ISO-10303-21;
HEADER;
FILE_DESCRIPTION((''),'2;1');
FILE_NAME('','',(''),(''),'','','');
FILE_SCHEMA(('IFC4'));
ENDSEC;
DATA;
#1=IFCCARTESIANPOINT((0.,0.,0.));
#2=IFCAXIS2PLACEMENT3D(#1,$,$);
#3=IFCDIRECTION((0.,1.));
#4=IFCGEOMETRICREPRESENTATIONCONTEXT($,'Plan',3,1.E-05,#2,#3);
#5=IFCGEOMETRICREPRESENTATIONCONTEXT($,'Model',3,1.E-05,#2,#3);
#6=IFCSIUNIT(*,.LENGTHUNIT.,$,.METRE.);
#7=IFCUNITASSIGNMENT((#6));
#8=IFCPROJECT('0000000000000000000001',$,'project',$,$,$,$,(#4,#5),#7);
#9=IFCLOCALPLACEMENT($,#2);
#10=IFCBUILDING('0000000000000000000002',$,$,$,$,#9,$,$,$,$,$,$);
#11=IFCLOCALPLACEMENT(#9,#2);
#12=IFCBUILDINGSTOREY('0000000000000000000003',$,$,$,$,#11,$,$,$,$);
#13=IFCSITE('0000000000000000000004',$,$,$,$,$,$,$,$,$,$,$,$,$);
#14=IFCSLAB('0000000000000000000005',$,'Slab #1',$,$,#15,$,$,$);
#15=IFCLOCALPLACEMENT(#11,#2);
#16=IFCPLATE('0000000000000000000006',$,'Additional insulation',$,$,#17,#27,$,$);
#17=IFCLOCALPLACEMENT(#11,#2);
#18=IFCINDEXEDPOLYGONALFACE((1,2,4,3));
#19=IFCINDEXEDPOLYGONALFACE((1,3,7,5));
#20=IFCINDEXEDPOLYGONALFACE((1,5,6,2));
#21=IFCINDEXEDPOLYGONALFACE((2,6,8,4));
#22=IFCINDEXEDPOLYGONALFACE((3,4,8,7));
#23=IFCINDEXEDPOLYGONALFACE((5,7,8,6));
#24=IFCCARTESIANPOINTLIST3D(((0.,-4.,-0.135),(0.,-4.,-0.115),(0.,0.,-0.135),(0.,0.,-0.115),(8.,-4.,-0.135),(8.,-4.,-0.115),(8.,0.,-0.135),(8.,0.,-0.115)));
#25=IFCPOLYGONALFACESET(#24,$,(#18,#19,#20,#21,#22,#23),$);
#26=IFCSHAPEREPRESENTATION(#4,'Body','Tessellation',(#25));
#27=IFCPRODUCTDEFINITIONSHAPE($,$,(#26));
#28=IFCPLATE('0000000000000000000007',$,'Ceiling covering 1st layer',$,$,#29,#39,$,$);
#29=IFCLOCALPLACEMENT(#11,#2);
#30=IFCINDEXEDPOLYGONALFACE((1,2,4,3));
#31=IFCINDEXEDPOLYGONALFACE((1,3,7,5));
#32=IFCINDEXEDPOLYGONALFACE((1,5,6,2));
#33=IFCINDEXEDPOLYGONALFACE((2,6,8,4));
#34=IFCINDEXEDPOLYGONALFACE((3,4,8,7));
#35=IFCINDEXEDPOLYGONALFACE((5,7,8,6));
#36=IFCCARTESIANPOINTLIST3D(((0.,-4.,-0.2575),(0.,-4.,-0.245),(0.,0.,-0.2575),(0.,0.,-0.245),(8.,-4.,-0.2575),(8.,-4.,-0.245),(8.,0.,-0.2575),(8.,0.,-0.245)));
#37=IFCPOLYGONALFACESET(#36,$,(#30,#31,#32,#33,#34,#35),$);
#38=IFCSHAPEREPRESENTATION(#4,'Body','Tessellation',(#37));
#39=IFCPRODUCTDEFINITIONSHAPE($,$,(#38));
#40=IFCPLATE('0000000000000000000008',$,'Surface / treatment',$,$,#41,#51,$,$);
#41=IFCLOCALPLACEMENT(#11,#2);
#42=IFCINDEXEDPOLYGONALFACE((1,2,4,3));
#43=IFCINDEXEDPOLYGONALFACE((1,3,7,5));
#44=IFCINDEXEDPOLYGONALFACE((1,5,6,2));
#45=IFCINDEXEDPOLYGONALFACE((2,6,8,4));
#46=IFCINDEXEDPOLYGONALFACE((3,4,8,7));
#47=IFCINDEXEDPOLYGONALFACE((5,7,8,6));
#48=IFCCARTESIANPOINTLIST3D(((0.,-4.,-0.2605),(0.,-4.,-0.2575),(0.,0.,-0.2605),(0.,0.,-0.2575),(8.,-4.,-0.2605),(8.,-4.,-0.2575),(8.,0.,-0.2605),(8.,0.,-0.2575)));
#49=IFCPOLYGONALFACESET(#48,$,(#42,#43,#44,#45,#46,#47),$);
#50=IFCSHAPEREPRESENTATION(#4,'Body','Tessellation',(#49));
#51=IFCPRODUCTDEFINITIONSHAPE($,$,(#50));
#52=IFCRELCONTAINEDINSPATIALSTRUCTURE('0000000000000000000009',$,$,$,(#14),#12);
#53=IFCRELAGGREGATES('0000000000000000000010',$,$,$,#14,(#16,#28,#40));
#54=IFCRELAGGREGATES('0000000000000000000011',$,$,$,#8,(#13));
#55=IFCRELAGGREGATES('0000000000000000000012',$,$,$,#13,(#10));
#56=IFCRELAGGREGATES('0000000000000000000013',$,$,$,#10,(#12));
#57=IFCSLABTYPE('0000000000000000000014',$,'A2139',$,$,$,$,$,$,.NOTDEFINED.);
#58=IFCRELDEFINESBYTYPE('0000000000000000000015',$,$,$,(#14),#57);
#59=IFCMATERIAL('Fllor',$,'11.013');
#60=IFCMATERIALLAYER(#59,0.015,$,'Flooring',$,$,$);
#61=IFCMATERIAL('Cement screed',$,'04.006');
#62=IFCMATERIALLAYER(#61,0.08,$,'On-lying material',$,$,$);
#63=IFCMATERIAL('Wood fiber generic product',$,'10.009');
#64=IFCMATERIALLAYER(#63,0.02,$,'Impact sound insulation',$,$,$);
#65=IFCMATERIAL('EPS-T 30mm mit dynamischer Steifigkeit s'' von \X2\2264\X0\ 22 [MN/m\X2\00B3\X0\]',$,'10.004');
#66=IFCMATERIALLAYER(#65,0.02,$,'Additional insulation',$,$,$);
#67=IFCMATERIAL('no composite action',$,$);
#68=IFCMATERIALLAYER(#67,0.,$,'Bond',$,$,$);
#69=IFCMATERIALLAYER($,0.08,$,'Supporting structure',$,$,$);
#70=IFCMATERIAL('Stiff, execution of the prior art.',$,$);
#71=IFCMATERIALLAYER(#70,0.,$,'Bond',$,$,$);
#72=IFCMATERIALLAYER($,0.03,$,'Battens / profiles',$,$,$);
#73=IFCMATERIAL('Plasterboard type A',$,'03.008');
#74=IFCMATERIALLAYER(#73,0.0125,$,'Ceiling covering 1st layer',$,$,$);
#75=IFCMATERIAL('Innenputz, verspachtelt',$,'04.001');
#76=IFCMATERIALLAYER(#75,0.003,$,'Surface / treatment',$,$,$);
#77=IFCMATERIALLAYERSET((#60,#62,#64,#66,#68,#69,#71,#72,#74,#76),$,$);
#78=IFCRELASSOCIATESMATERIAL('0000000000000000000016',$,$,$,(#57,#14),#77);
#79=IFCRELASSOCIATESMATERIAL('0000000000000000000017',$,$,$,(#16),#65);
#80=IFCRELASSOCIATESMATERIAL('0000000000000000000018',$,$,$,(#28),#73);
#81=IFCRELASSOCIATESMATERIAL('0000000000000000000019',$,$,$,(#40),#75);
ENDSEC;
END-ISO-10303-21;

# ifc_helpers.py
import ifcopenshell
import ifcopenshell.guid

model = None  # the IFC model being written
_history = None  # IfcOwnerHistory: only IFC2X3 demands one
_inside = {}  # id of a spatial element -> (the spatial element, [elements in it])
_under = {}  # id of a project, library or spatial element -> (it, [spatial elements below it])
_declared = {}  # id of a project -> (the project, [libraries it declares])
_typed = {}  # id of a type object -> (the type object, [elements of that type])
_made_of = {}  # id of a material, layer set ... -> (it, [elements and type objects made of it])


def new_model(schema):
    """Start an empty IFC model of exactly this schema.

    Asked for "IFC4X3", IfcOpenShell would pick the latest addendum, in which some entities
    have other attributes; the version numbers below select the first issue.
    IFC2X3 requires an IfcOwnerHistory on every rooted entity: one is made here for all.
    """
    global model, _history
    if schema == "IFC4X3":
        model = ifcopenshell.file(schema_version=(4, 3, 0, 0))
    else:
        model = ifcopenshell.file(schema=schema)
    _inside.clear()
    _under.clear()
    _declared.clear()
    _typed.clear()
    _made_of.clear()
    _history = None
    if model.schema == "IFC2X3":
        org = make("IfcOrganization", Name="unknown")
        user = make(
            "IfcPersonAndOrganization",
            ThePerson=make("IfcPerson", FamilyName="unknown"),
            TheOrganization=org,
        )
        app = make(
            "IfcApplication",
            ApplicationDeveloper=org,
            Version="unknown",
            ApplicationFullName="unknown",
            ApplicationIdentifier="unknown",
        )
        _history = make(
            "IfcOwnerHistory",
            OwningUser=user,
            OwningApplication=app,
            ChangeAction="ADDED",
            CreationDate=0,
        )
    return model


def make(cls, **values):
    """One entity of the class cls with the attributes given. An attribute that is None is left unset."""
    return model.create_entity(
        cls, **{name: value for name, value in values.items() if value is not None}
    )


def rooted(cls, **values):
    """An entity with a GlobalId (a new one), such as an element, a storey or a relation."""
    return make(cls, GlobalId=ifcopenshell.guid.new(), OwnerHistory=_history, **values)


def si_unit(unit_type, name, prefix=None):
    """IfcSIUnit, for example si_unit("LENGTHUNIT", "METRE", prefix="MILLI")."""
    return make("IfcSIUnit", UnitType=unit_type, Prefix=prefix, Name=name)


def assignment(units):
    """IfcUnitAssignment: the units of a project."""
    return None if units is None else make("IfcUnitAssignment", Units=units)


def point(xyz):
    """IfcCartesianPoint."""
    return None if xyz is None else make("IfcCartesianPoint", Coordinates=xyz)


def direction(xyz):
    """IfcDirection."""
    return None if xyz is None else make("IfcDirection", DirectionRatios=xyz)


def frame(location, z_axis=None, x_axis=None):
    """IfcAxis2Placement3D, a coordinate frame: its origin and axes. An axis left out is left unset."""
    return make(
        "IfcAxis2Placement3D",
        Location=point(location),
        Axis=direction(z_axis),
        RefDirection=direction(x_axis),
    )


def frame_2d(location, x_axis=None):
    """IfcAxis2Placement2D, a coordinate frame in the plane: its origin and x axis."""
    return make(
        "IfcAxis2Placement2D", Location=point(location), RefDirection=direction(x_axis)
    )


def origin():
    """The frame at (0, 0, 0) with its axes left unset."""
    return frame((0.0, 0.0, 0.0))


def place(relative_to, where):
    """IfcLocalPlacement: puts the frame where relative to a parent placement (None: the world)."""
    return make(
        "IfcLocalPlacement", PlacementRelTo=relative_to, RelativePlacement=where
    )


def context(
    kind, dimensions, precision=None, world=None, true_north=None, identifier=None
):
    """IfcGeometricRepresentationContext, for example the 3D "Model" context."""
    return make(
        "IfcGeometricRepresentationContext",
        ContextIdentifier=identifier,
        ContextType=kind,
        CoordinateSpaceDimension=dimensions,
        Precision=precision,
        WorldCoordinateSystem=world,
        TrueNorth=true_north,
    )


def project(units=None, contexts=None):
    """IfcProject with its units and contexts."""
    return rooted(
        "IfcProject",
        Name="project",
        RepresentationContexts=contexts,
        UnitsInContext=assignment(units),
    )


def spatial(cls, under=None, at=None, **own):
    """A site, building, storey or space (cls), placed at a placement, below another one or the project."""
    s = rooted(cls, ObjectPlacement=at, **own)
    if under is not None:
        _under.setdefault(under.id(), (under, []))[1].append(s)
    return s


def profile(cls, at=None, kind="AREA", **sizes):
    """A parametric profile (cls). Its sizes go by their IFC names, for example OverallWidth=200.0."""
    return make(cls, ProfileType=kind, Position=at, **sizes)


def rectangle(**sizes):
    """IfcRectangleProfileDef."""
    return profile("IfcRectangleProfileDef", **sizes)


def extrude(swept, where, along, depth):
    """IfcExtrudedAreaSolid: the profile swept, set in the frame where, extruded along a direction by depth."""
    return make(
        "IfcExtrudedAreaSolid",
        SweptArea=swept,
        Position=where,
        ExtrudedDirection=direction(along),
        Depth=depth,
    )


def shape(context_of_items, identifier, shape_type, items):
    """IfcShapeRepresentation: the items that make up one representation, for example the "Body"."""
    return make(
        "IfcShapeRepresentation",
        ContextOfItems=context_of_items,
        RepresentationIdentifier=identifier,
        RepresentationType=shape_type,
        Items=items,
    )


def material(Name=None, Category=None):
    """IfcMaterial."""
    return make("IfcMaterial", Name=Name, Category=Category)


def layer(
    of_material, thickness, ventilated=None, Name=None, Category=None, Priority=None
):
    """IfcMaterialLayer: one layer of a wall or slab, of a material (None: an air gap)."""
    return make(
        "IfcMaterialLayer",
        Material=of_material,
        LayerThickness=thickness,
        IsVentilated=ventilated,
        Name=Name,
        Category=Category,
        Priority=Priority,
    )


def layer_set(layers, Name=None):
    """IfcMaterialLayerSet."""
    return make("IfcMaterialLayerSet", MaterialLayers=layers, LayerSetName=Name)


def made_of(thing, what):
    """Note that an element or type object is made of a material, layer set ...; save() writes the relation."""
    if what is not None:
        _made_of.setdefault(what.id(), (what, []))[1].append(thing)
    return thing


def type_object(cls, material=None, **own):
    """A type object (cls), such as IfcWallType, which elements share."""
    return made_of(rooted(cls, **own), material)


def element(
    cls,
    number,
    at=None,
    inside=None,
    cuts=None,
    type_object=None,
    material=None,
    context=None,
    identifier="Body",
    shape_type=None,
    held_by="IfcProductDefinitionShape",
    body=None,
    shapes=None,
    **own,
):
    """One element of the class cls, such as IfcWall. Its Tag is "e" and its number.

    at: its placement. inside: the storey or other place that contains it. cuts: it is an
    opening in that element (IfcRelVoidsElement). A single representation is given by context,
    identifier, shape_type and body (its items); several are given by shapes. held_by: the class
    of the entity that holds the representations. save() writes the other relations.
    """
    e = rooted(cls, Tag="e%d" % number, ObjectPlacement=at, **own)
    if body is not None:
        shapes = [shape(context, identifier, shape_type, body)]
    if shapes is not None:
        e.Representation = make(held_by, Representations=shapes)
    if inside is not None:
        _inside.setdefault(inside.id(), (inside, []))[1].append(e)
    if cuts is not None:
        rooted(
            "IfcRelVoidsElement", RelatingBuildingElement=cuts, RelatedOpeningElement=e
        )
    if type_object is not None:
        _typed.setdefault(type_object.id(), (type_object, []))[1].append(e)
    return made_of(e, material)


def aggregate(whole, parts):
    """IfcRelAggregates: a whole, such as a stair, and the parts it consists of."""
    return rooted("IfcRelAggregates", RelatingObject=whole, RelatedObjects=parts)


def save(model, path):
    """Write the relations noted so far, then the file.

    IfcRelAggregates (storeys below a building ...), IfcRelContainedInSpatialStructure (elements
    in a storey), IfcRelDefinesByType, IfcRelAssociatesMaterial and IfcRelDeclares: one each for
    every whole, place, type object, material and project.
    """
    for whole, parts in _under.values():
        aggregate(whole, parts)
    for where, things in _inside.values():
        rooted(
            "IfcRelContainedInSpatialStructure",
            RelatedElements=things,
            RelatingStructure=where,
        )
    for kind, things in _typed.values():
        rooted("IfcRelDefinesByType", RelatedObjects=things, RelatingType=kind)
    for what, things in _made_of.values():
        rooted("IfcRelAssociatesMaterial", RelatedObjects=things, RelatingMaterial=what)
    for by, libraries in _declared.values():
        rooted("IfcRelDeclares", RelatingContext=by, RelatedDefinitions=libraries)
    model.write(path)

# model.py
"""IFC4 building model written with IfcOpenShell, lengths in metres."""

from ifc_helpers import new_model, si_unit, direction, frame, frame_2d, origin, place, context, project, spatial, rectangle, extrude, material, layer, layer_set, type_object, element, aggregate, save


model = new_model("IFC4")

# Units and contexts
plan_context = context("Plan", 3, precision=1e-05, world=origin(), true_north=direction((0.0, 1.0)))
model_context = context("Model", 3, precision=1e-05, world=origin(), true_north=direction((0.0, 1.0)))
ifc_project = project(units=[si_unit("LENGTHUNIT", "METRE")], contexts=[plan_context, model_context])

# Site, building, storey
site = spatial("IfcSite", under=ifc_project)
building_placement = place(None, origin())
building = spatial("IfcBuilding", under=site, at=building_placement)
storey_placement = place(building_placement, origin())
storey = spatial("IfcBuildingStorey", under=building, at=storey_placement)

# Slab, plates
ifc_material_1 = material(Name="Fllor", Category="11.013")
ifc_layer_1 = layer(ifc_material_1, 0.015, Name="Flooring")
ifc_material_2 = material(Name="Cement screed", Category="04.006")
ifc_layer_2 = layer(ifc_material_2, 0.08, Name="On-lying material")
ifc_material_3 = material(Name="Wood fiber generic product", Category="10.009")
ifc_layer_3 = layer(ifc_material_3, 0.02, Name="Impact sound insulation")
ifc_material_4 = material(Name="EPS-T 30mm mit dynamischer Steifigkeit s' von ≤ 22 [MN/m³]", Category="10.004")
ifc_layer_4 = layer(ifc_material_4, 0.02, Name="Additional insulation")
ifc_material_5 = material(Name="no composite action")
ifc_layer_5 = layer(ifc_material_5, 0.0, Name="Bond")
ifc_layer_6 = layer(None, 0.08, Name="Supporting structure")
ifc_material_6 = material(Name="Stiff, execution of the prior art.")
ifc_layer_7 = layer(ifc_material_6, 0.0, Name="Bond")
ifc_layer_8 = layer(None, 0.03, Name="Battens / profiles")
ifc_material_7 = material(Name="Plasterboard type A", Category="03.008")
ifc_layer_9 = layer(ifc_material_7, 0.0125, Name="Ceiling covering 1st layer")
ifc_material_8 = material(Name="Innenputz, verspachtelt", Category="04.001")
ifc_layer_10 = layer(ifc_material_8, 0.003, Name="Surface / treatment")
ifc_layer_set = layer_set([ifc_layer_1, ifc_layer_2, ifc_layer_3, ifc_layer_4, ifc_layer_5, ifc_layer_6, ifc_layer_7, ifc_layer_8, ifc_layer_9, ifc_layer_10])
slab_type = type_object("IfcSlabType", Name="A2139", PredefinedType="NOTDEFINED", material=ifc_layer_set)
slab_placement = place(None, frame((0.0, 0.0, 0.0), z_axis=(0.0, 0.0, -1.0), x_axis=(1.0, 0.0, 0.0)))
slab = element("IfcSlab", 1, at=slab_placement, inside=storey, type_object=slab_type, material=ifc_layer_set, Name="Slab #1")
plate_1_placement = place(slab_placement, origin())
plate_1 = element("IfcPlate", 2, at=plate_1_placement, material=ifc_material_4, Name="Additional insulation", context=plan_context, shape_type="SweptSolid", body=[
    extrude(rectangle(XDim=8.0, YDim=4.0, at=frame_2d((4.0, 2.0), x_axis=(1.0, 0.0))), frame((0.0, 0.0, 0.115), z_axis=(0.0, 0.0, 1.0), x_axis=(1.0, 0.0, 0.0)), (0.0, 0.0, 1.0), 0.02),
])
plate_2_placement = place(slab_placement, origin())
plate_2 = element("IfcPlate", 3, at=plate_2_placement, material=ifc_material_7, Name="Ceiling covering 1st layer", context=plan_context, shape_type="SweptSolid", body=[
    extrude(rectangle(XDim=8.0, YDim=4.0, at=frame_2d((4.0, 2.0), x_axis=(1.0, 0.0))), frame((0.0, 0.0, 0.245), z_axis=(0.0, 0.0, 1.0), x_axis=(1.0, 0.0, 0.0)), (0.0, 0.0, 1.0), 0.0125),
])
plate_3_placement = place(slab_placement, origin())
plate_3 = element("IfcPlate", 4, at=plate_3_placement, material=ifc_material_8, Name="Surface / treatment", context=plan_context, shape_type="SweptSolid", body=[
    extrude(rectangle(XDim=8.0, YDim=4.0, at=frame_2d((4.0, 2.0), x_axis=(1.0, 0.0))), frame((0.0, 0.0, 0.2575), z_axis=(0.0, 0.0, 1.0), x_axis=(1.0, 0.0, 0.0)), (0.0, 0.0, 1.0), 0.003),
])
aggregate(slab, [plate_1, plate_2, plate_3])

save(model, "model.ifc")
